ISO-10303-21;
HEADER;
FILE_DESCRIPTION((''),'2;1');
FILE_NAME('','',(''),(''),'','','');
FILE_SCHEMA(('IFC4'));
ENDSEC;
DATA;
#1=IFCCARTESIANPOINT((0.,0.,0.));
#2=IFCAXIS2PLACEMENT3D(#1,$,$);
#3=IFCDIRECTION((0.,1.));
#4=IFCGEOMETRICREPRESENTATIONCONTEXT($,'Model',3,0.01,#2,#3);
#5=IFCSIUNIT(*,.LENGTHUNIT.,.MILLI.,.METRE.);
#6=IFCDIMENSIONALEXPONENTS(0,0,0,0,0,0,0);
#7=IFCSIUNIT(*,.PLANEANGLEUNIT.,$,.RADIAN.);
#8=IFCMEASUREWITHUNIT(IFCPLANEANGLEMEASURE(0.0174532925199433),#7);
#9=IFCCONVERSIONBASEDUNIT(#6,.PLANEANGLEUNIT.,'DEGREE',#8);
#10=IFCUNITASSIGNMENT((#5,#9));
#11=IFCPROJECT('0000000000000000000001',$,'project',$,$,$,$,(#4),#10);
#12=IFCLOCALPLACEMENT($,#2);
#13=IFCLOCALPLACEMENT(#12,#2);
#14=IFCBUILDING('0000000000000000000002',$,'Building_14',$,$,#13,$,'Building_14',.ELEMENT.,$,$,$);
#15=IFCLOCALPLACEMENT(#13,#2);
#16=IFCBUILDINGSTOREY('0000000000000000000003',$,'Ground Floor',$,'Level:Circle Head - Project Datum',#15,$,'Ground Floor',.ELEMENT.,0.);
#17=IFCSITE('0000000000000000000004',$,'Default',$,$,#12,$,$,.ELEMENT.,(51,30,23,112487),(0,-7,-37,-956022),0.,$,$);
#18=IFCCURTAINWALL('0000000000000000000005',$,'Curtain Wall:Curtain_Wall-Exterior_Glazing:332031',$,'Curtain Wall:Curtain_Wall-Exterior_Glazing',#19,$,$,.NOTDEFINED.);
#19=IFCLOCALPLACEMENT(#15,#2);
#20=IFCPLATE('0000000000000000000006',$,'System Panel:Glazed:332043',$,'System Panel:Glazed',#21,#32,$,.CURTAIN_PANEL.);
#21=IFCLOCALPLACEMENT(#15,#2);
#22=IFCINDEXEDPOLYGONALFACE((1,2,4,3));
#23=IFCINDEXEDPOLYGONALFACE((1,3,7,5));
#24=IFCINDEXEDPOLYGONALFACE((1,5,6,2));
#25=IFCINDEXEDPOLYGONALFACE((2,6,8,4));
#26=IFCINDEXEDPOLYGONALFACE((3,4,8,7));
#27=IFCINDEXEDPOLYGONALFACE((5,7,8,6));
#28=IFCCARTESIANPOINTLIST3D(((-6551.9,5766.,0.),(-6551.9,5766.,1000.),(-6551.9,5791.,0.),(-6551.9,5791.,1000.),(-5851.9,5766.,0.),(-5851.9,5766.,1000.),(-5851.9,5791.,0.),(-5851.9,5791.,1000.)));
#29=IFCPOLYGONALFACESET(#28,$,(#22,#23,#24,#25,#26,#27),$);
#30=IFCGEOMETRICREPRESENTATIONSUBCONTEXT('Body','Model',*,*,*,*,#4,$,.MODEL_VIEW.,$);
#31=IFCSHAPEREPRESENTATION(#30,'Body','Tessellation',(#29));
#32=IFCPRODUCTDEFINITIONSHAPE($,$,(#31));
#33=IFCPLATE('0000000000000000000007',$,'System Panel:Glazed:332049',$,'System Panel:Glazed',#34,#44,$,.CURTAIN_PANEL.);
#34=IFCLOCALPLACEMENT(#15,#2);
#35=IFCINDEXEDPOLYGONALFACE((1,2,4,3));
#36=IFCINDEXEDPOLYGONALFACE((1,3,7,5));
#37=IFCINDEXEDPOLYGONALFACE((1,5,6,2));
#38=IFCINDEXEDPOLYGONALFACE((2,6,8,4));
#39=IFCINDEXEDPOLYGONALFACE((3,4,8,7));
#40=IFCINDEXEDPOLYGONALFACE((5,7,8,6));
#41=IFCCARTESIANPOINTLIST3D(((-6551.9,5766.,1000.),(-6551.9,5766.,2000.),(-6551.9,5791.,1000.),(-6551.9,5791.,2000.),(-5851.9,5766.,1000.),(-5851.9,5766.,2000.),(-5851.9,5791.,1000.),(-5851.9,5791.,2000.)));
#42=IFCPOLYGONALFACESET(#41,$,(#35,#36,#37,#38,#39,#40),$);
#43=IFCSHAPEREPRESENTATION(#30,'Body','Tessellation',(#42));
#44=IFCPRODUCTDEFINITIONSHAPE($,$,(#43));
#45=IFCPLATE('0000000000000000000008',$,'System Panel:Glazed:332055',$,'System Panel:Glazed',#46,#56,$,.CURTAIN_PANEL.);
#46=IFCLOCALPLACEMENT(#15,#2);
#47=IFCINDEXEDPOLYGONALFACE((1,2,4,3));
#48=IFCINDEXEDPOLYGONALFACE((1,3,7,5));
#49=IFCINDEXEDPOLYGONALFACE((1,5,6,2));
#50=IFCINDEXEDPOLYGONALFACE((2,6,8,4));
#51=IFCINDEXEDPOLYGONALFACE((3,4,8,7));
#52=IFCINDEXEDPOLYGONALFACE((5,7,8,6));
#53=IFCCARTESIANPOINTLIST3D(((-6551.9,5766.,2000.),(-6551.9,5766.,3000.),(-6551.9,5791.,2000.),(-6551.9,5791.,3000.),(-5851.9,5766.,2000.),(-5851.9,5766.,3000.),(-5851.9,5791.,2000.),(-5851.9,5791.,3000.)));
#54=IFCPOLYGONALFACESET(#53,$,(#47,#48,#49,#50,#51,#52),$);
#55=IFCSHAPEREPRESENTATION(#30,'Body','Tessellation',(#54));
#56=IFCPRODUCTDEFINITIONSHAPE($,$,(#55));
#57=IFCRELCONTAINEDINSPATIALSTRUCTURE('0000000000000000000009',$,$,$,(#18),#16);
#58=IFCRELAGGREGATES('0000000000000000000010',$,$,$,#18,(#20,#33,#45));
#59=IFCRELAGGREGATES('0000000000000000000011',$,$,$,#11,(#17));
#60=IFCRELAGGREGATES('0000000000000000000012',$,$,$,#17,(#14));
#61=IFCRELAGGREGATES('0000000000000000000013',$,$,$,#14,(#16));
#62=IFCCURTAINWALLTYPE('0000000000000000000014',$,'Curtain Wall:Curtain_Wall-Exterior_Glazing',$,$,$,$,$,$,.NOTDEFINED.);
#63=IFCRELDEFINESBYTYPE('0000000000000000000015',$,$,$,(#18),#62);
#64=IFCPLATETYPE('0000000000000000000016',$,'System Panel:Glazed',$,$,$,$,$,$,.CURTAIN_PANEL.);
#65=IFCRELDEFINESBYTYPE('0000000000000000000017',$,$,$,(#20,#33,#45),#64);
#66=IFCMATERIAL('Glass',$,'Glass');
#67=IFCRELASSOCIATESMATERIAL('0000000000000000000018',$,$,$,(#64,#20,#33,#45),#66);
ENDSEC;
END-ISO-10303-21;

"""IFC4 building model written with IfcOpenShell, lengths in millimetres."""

from ifc_helpers import new_model, entity, si_unit, converted_unit, direction, frame, origin, place, context, subcontext, project, spatial, indexed_curve, outline, extrude, source, transform, mapped, material, type_object, type_shapes, element, aggregate, save


model = new_model("IFC4")

# Units and contexts
model_context = context("Model", 3, precision=0.01, world=origin(), true_north=direction((0.0, 1.0)))
body_context = subcontext(model_context, "Body", "Model", "MODEL_VIEW")
ifc_project = project(units=[si_unit("LENGTHUNIT", "METRE", prefix="MILLI"), converted_unit("PLANEANGLEUNIT", "DEGREE", entity("IfcPlaneAngleMeasure", 0.0174532925199433), si_unit("PLANEANGLEUNIT", "RADIAN"), dimensions=[0, 0, 0, 0, 0, 0, 0])], contexts=[model_context])

# Site, building, storey
site_placement = place(None, origin())
site = spatial("IfcSite", under=ifc_project, at=site_placement, Name="Default", CompositionType="ELEMENT", RefLatitude=(51, 30, 23, 112487), RefLongitude=(0, -7, -37, -956022), RefElevation=0.0)
building_placement = place(site_placement, origin())
building = spatial("IfcBuilding", under=site, at=building_placement, Name="Building_14", LongName="Building_14", CompositionType="ELEMENT")
storey_placement = place(building_placement, origin())
storey = spatial("IfcBuildingStorey", under=building, at=storey_placement, Name="Ground Floor", ObjectType="Level:Circle Head - Project Datum", LongName="Ground Floor", CompositionType="ELEMENT", Elevation=0.0)

# Curtain wall, plates
curtain_wall_type = type_object("IfcCurtainWallType", Name="Curtain Wall:Curtain_Wall-Exterior_Glazing", PredefinedType="NOTDEFINED")
ifc_material = material(Name="Glass", Category="Glass")
curtain_wall_1_placement = place(storey_placement, origin())
curtain_wall_1 = element("IfcCurtainWall", 1, at=curtain_wall_1_placement, inside=storey, type_object=curtain_wall_type, Name="Curtain Wall:Curtain_Wall-Exterior_Glazing:332031", ObjectType="Curtain Wall:Curtain_Wall-Exterior_Glazing", PredefinedType="NOTDEFINED")
plate_type_1 = type_object("IfcPlateType", Name="System Panel:Glazed", PredefinedType="CURTAIN_PANEL", material=ifc_material)
shared_shape_1 = source(origin(), body_context, "Body", "SweptSolid", [
    extrude(outline(indexed_curve([(-12.5, -350.0), (12.5, -350.0), (12.5, 350.0), (-12.5, 350.0), (-12.5, -350.0)], self_intersect=False)), frame((0.0, -37.0, 0.0), z_axis=(0.0, 0.0, 1.0), x_axis=(0.0, 1.0, 0.0)), (0.0, 0.0, 1.0), 1000.0),
])
type_shapes(plate_type_1, [shared_shape_1])
plate_1_placement = place(curtain_wall_1_placement, frame((-6201.9, 5815.5, 0.0)))
plate_1 = element("IfcPlate", 2, at=plate_1_placement, type_object=plate_type_1, material=ifc_material, Name="System Panel:Glazed:332043", ObjectType="System Panel:Glazed", PredefinedType="CURTAIN_PANEL", context=body_context, shape_type="MappedRepresentation", body=[
    mapped(shared_shape_1, transform((0.0, 0.0, 0.0), scale=1.0)),
])
plate_2_placement = place(curtain_wall_1_placement, frame((-6201.9, 5815.5, 1000.0)))
plate_2 = element("IfcPlate", 3, at=plate_2_placement, type_object=plate_type_1, material=ifc_material, Name="System Panel:Glazed:332049", ObjectType="System Panel:Glazed", PredefinedType="CURTAIN_PANEL", context=body_context, shape_type="MappedRepresentation", body=[
    mapped(shared_shape_1, transform((0.0, 0.0, 0.0), scale=1.0)),
])
plate_3_placement = place(curtain_wall_1_placement, frame((-6201.9, 5815.5, 2000.0)))
plate_3 = element("IfcPlate", 4, at=plate_3_placement, type_object=plate_type_1, material=ifc_material, Name="System Panel:Glazed:332055", ObjectType="System Panel:Glazed", PredefinedType="CURTAIN_PANEL", context=body_context, shape_type="MappedRepresentation", body=[
    mapped(shared_shape_1, transform((0.0, 0.0, 0.0), scale=1.0)),
])
aggregate(curtain_wall_1, [plate_1, plate_2, plate_3])

save(model, "model.ifc")
